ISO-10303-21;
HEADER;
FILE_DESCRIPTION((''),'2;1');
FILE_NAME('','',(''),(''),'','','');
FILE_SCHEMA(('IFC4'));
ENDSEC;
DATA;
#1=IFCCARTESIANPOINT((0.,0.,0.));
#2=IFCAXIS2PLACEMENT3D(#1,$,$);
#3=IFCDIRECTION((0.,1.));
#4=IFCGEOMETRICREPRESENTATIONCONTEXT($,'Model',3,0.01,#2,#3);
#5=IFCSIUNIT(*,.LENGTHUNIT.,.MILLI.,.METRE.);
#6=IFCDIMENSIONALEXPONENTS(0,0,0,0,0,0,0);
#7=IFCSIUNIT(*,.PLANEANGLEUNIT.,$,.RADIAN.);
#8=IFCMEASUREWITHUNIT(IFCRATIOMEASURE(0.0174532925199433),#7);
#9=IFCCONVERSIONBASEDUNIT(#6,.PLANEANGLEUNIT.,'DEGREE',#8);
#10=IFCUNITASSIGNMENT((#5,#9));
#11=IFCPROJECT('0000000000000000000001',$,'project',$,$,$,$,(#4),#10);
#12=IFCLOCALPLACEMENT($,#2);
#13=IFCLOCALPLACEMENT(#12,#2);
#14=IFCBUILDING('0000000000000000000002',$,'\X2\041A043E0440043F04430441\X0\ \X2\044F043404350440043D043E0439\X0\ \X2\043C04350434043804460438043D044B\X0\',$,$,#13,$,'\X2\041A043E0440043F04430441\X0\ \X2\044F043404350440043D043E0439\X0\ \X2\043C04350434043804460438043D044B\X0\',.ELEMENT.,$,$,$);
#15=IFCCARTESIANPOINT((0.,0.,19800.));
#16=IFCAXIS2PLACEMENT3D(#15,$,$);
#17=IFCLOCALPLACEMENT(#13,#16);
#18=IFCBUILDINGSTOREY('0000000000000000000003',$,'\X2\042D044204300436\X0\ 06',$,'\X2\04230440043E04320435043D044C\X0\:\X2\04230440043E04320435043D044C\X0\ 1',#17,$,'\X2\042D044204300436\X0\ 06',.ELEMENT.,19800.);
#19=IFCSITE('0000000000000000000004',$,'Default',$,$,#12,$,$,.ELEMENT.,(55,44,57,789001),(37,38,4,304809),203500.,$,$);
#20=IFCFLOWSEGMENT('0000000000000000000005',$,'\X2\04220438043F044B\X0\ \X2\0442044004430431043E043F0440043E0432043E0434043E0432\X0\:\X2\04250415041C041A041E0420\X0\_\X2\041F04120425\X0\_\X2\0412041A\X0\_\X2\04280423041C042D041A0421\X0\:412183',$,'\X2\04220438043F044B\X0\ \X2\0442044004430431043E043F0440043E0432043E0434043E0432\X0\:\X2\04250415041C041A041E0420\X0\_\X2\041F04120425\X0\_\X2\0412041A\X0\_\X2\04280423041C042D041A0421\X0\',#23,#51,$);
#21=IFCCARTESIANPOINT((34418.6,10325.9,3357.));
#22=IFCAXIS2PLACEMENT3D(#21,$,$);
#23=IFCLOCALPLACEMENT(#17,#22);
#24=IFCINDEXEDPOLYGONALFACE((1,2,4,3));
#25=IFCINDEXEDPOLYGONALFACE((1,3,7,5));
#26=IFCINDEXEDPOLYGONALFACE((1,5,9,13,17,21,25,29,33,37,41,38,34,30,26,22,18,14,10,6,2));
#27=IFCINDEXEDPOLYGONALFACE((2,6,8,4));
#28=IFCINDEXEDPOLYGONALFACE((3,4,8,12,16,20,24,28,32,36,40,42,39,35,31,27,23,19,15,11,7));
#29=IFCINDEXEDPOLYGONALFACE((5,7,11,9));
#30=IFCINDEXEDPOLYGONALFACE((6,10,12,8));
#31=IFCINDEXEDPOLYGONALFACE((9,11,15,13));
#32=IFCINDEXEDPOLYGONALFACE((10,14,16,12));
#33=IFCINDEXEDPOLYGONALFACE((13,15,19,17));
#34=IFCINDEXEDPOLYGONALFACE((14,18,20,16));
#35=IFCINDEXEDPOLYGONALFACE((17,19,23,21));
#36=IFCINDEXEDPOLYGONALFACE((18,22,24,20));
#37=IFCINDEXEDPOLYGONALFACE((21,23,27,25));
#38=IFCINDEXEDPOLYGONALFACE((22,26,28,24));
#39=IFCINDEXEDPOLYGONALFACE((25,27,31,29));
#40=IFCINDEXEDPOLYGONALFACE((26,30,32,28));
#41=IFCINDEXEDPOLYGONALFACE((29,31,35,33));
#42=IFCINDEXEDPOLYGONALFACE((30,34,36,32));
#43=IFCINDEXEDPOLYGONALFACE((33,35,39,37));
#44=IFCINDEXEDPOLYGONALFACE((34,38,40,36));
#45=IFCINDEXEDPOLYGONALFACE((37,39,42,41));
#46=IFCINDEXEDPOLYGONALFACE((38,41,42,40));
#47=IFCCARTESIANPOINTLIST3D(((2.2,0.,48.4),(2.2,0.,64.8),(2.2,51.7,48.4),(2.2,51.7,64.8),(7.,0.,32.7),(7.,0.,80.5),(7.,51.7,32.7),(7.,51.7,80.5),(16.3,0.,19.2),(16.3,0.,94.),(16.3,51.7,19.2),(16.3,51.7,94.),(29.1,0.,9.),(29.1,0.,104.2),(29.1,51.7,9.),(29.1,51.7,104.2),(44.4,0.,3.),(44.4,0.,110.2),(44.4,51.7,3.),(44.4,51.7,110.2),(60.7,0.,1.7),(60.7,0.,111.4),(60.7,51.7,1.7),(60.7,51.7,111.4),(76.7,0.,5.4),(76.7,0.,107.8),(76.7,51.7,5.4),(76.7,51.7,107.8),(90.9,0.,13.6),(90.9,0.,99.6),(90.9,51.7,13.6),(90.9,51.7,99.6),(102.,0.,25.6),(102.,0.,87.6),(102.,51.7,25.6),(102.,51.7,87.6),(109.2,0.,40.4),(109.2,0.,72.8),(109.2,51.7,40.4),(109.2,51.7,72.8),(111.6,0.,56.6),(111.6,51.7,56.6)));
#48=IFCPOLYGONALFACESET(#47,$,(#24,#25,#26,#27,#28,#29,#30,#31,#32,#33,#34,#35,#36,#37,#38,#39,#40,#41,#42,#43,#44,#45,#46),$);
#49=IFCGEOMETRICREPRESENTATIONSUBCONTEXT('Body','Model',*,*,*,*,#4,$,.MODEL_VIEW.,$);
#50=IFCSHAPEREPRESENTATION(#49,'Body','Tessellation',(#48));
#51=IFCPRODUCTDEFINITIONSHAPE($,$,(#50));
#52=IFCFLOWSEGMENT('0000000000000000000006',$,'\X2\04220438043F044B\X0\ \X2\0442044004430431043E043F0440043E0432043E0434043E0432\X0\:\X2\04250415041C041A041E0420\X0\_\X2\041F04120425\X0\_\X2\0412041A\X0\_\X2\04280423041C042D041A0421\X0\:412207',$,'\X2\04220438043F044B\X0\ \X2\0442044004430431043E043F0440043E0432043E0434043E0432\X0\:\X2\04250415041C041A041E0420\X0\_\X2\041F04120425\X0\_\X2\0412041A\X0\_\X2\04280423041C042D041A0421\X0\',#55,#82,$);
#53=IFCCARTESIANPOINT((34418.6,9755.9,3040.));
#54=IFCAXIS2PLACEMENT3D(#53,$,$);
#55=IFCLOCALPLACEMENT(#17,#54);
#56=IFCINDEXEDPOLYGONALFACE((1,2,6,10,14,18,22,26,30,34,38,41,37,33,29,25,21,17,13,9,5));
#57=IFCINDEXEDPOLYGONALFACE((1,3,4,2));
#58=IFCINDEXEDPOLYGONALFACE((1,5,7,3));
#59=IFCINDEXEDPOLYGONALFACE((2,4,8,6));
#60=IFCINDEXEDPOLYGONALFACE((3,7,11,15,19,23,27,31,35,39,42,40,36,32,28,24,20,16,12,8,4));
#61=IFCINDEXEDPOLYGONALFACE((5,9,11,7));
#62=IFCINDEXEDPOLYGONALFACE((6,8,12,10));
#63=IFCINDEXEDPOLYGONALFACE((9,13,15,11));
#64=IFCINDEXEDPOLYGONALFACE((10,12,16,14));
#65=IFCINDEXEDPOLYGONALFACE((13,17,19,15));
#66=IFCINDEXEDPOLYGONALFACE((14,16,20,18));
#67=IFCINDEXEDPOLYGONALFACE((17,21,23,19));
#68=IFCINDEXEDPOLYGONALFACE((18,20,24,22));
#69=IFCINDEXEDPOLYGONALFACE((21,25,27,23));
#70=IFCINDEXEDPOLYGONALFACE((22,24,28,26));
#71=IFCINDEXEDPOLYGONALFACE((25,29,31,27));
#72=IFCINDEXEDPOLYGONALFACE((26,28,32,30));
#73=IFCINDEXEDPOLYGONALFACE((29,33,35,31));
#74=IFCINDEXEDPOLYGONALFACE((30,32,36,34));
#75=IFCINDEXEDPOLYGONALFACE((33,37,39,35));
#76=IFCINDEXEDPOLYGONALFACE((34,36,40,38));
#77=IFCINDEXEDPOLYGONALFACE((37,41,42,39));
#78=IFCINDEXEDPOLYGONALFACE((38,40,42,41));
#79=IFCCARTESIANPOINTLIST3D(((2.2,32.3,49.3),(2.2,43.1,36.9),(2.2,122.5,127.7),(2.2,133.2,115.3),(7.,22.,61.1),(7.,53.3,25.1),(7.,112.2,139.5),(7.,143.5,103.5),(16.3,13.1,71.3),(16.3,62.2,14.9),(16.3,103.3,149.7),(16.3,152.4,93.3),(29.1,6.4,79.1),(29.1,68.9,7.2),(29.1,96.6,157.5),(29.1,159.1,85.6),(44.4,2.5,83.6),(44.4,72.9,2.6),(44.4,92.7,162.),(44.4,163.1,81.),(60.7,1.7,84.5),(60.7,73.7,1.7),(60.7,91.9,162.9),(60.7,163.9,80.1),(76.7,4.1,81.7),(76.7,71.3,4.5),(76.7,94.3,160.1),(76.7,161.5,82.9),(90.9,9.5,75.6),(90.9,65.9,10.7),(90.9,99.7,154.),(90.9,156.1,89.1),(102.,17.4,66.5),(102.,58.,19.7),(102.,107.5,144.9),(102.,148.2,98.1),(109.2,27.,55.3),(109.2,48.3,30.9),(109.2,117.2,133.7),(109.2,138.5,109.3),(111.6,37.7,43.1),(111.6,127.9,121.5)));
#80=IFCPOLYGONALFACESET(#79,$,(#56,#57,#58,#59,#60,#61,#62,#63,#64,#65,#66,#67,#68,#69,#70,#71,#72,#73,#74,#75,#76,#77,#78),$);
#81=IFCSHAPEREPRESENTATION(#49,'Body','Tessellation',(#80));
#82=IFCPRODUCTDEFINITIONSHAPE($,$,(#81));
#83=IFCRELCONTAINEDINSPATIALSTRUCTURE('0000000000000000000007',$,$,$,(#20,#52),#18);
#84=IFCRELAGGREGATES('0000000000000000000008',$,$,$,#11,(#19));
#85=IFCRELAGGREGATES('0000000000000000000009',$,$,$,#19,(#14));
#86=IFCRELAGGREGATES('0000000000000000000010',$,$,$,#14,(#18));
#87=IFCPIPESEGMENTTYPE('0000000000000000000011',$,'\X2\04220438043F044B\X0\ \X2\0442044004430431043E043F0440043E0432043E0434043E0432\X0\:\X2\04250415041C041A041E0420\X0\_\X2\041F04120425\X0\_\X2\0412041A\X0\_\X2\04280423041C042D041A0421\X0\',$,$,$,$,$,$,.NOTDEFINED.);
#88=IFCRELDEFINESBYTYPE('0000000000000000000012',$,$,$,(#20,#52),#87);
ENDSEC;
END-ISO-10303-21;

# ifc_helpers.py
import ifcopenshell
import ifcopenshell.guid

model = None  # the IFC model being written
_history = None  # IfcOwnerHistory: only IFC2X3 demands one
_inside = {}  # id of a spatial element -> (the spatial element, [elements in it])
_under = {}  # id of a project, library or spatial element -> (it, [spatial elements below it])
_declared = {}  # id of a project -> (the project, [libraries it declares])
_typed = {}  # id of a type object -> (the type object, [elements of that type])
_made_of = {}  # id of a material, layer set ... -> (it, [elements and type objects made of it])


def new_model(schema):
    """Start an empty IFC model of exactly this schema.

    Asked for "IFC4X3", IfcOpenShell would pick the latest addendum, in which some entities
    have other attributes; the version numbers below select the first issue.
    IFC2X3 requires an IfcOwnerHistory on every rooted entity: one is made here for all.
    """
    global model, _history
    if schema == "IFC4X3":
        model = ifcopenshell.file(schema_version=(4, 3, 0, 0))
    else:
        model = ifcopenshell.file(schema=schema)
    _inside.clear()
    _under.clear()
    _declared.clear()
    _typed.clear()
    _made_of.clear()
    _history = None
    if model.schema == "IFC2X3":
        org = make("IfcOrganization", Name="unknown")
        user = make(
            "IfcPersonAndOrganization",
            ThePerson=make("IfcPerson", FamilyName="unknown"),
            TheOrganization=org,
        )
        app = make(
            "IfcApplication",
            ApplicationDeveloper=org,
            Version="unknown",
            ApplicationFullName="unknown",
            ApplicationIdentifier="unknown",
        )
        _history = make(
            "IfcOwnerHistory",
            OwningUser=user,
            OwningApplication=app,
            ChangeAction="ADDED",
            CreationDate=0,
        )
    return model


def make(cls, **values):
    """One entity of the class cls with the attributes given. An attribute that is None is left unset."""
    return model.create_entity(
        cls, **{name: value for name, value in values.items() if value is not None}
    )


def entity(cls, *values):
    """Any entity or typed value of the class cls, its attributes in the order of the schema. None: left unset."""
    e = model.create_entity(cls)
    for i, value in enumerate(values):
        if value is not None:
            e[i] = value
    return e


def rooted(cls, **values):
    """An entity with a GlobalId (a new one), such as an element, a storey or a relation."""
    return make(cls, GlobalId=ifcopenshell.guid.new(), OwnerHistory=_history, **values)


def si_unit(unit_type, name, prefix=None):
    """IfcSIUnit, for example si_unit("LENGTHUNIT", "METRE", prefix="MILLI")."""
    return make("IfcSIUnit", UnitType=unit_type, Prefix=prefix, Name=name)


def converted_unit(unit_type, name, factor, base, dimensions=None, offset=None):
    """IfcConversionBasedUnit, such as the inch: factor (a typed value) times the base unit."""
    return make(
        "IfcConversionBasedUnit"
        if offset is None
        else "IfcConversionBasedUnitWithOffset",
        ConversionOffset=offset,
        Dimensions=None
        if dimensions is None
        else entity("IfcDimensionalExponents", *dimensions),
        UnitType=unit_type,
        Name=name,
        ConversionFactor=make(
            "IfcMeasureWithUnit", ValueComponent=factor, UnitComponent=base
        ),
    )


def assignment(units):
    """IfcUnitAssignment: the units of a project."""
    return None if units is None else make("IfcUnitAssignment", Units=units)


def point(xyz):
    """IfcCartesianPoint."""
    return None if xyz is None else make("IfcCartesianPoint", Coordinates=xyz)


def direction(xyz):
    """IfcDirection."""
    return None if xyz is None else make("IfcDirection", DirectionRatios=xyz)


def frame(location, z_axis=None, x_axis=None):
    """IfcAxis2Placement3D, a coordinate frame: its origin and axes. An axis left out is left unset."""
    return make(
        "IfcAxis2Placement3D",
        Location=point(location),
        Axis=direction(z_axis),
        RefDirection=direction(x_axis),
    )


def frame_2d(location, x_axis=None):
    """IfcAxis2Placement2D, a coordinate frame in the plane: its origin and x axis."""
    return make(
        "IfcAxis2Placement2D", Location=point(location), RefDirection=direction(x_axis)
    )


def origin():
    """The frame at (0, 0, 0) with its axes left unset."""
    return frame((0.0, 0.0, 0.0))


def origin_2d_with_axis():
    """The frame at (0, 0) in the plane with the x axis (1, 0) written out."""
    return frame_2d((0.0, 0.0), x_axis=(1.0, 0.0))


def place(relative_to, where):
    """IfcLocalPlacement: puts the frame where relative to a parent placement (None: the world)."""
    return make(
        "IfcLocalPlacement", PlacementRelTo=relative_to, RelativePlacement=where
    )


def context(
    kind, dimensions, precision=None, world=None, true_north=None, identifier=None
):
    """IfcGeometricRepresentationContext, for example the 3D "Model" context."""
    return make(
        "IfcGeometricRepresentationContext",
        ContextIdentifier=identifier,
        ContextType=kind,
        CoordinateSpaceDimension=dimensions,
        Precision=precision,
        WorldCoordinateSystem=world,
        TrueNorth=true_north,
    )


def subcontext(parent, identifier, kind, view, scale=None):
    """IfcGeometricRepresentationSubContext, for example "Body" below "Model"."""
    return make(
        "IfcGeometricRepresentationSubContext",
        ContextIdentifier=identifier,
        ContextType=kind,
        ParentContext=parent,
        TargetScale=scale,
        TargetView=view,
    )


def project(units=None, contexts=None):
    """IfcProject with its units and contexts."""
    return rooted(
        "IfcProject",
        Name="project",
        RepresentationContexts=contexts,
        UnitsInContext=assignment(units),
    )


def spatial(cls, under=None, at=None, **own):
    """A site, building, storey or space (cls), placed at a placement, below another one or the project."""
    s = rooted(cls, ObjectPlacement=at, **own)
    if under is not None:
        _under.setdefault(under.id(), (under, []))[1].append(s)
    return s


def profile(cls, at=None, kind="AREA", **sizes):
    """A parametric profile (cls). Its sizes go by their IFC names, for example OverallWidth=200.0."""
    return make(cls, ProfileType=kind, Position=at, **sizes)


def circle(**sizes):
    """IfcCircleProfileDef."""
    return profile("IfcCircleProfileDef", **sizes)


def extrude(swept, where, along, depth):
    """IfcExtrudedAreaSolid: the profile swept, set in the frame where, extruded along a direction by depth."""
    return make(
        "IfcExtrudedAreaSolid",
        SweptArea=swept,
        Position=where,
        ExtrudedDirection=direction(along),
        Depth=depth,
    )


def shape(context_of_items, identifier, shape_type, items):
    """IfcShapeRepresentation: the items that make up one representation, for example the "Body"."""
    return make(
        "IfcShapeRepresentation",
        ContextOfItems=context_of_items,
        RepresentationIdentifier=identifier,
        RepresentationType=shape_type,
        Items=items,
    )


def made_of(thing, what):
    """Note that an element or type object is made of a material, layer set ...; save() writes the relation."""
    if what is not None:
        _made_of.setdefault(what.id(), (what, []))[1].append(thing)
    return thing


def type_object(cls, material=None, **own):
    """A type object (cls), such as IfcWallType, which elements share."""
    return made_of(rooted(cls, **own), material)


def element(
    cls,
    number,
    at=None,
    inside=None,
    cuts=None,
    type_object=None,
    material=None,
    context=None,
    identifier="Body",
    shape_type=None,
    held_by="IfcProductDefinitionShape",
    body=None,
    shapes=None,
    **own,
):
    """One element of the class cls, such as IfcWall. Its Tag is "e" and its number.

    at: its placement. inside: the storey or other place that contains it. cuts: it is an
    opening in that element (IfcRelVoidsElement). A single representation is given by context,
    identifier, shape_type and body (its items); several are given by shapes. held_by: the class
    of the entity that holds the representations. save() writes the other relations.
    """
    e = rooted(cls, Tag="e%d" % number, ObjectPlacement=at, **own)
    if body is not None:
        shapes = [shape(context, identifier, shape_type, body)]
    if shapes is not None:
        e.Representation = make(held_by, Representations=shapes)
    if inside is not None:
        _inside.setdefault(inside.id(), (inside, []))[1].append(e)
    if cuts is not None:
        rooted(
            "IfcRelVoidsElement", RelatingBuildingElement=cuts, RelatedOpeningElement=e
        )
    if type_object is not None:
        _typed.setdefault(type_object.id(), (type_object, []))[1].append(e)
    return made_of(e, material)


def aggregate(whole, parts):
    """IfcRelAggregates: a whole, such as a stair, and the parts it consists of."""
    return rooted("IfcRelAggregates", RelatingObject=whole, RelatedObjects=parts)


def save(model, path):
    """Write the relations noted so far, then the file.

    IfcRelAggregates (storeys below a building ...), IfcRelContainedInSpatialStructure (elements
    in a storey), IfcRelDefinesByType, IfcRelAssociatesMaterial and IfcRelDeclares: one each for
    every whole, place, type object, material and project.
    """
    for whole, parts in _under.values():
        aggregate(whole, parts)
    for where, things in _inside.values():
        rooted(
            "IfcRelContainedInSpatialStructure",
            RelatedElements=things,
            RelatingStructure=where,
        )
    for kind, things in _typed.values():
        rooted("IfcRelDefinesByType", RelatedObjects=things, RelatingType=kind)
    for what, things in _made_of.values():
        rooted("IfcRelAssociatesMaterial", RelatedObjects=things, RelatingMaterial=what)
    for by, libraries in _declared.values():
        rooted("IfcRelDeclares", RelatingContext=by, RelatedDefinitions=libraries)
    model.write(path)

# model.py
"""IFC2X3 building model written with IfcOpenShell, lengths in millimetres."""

from ifc_helpers import new_model, entity, si_unit, converted_unit, direction, frame, origin, origin_2d_with_axis, place, context, subcontext, project, spatial, circle, extrude, type_object, element, save


model = new_model("IFC2X3")

# Units and contexts
model_context = context("Model", 3, precision=0.01, world=origin(), true_north=direction((0.0, 1.0)))
body_context = subcontext(model_context, "Body", "Model", "MODEL_VIEW")
ifc_project = project(units=[si_unit("LENGTHUNIT", "METRE", prefix="MILLI"), converted_unit("PLANEANGLEUNIT", "DEGREE", entity("IfcRatioMeasure", 0.0174532925199433), si_unit("PLANEANGLEUNIT", "RADIAN"), dimensions=[0, 0, 0, 0, 0, 0, 0])], contexts=[model_context])

# Site, building, storey
site_placement = place(None, frame((0.0, 0.0, 0.0)))
site = spatial("IfcSite", under=ifc_project, at=site_placement, Name="Default", CompositionType="ELEMENT", RefLatitude=(55, 44, 57, 789001), RefLongitude=(37, 38, 4, 304809), RefElevation=203500.0)
building_placement = place(site_placement, origin())
building = spatial("IfcBuilding", under=site, at=building_placement, Name="Корпус ядерной медицины", LongName="Корпус ядерной медицины", CompositionType="ELEMENT")
storey_placement = place(building_placement, frame((0.0, 0.0, 19800.0)))
storey = spatial("IfcBuildingStorey", under=building, at=storey_placement, Name="Этаж 06", ObjectType="Уровень:Уровень 1", LongName="Этаж 06", CompositionType="ELEMENT", Elevation=19800.0)

# Flow segments
pipe_segment_type = type_object("IfcPipeSegmentType", Name="Типы трубопроводов:ХЕМКОР_ПВХ_ВК_ШУМЭКС", PredefinedType="NOTDEFINED")
flow_segment_1_placement = place(storey_placement, frame((34418.6, 10325.9, 3357.0)))
element("IfcFlowSegment", 1, at=flow_segment_1_placement, inside=storey, type_object=pipe_segment_type, Name="Типы трубопроводов:ХЕМКОР_ПВХ_ВК_ШУМЭКС:412183", ObjectType="Типы трубопроводов:ХЕМКОР_ПВХ_ВК_ШУМЭКС", context=body_context, shape_type="SweptSolid", body=[
    extrude(circle(Radius=55.0, at=origin_2d_with_axis()), frame((56.6, 0.0, 56.6), z_axis=(0.0, 1.0, 0.0), x_axis=(1.0, 0.0, 0.0)), (0.0, 0.0, 1.0), 51.7),
])
flow_segment_2_placement = place(storey_placement, frame((34418.6, 9755.9, 3040.0)))
element("IfcFlowSegment", 2, at=flow_segment_2_placement, inside=storey, type_object=pipe_segment_type, Name="Типы трубопроводов:ХЕМКОР_ПВХ_ВК_ШУМЭКС:412207", ObjectType="Типы трубопроводов:ХЕМКОР_ПВХ_ВК_ШУМЭКС", context=body_context, shape_type="SweptSolid", body=[
    extrude(circle(Radius=55.0, at=origin_2d_with_axis()), frame((56.6, 37.7, 43.1), z_axis=(0.0, 0.75471, 0.656059), x_axis=(1.0, 0.0, 0.0)), (0.0, 0.0, 1.0), 119.5),
])

save(model, "model.ifc")
